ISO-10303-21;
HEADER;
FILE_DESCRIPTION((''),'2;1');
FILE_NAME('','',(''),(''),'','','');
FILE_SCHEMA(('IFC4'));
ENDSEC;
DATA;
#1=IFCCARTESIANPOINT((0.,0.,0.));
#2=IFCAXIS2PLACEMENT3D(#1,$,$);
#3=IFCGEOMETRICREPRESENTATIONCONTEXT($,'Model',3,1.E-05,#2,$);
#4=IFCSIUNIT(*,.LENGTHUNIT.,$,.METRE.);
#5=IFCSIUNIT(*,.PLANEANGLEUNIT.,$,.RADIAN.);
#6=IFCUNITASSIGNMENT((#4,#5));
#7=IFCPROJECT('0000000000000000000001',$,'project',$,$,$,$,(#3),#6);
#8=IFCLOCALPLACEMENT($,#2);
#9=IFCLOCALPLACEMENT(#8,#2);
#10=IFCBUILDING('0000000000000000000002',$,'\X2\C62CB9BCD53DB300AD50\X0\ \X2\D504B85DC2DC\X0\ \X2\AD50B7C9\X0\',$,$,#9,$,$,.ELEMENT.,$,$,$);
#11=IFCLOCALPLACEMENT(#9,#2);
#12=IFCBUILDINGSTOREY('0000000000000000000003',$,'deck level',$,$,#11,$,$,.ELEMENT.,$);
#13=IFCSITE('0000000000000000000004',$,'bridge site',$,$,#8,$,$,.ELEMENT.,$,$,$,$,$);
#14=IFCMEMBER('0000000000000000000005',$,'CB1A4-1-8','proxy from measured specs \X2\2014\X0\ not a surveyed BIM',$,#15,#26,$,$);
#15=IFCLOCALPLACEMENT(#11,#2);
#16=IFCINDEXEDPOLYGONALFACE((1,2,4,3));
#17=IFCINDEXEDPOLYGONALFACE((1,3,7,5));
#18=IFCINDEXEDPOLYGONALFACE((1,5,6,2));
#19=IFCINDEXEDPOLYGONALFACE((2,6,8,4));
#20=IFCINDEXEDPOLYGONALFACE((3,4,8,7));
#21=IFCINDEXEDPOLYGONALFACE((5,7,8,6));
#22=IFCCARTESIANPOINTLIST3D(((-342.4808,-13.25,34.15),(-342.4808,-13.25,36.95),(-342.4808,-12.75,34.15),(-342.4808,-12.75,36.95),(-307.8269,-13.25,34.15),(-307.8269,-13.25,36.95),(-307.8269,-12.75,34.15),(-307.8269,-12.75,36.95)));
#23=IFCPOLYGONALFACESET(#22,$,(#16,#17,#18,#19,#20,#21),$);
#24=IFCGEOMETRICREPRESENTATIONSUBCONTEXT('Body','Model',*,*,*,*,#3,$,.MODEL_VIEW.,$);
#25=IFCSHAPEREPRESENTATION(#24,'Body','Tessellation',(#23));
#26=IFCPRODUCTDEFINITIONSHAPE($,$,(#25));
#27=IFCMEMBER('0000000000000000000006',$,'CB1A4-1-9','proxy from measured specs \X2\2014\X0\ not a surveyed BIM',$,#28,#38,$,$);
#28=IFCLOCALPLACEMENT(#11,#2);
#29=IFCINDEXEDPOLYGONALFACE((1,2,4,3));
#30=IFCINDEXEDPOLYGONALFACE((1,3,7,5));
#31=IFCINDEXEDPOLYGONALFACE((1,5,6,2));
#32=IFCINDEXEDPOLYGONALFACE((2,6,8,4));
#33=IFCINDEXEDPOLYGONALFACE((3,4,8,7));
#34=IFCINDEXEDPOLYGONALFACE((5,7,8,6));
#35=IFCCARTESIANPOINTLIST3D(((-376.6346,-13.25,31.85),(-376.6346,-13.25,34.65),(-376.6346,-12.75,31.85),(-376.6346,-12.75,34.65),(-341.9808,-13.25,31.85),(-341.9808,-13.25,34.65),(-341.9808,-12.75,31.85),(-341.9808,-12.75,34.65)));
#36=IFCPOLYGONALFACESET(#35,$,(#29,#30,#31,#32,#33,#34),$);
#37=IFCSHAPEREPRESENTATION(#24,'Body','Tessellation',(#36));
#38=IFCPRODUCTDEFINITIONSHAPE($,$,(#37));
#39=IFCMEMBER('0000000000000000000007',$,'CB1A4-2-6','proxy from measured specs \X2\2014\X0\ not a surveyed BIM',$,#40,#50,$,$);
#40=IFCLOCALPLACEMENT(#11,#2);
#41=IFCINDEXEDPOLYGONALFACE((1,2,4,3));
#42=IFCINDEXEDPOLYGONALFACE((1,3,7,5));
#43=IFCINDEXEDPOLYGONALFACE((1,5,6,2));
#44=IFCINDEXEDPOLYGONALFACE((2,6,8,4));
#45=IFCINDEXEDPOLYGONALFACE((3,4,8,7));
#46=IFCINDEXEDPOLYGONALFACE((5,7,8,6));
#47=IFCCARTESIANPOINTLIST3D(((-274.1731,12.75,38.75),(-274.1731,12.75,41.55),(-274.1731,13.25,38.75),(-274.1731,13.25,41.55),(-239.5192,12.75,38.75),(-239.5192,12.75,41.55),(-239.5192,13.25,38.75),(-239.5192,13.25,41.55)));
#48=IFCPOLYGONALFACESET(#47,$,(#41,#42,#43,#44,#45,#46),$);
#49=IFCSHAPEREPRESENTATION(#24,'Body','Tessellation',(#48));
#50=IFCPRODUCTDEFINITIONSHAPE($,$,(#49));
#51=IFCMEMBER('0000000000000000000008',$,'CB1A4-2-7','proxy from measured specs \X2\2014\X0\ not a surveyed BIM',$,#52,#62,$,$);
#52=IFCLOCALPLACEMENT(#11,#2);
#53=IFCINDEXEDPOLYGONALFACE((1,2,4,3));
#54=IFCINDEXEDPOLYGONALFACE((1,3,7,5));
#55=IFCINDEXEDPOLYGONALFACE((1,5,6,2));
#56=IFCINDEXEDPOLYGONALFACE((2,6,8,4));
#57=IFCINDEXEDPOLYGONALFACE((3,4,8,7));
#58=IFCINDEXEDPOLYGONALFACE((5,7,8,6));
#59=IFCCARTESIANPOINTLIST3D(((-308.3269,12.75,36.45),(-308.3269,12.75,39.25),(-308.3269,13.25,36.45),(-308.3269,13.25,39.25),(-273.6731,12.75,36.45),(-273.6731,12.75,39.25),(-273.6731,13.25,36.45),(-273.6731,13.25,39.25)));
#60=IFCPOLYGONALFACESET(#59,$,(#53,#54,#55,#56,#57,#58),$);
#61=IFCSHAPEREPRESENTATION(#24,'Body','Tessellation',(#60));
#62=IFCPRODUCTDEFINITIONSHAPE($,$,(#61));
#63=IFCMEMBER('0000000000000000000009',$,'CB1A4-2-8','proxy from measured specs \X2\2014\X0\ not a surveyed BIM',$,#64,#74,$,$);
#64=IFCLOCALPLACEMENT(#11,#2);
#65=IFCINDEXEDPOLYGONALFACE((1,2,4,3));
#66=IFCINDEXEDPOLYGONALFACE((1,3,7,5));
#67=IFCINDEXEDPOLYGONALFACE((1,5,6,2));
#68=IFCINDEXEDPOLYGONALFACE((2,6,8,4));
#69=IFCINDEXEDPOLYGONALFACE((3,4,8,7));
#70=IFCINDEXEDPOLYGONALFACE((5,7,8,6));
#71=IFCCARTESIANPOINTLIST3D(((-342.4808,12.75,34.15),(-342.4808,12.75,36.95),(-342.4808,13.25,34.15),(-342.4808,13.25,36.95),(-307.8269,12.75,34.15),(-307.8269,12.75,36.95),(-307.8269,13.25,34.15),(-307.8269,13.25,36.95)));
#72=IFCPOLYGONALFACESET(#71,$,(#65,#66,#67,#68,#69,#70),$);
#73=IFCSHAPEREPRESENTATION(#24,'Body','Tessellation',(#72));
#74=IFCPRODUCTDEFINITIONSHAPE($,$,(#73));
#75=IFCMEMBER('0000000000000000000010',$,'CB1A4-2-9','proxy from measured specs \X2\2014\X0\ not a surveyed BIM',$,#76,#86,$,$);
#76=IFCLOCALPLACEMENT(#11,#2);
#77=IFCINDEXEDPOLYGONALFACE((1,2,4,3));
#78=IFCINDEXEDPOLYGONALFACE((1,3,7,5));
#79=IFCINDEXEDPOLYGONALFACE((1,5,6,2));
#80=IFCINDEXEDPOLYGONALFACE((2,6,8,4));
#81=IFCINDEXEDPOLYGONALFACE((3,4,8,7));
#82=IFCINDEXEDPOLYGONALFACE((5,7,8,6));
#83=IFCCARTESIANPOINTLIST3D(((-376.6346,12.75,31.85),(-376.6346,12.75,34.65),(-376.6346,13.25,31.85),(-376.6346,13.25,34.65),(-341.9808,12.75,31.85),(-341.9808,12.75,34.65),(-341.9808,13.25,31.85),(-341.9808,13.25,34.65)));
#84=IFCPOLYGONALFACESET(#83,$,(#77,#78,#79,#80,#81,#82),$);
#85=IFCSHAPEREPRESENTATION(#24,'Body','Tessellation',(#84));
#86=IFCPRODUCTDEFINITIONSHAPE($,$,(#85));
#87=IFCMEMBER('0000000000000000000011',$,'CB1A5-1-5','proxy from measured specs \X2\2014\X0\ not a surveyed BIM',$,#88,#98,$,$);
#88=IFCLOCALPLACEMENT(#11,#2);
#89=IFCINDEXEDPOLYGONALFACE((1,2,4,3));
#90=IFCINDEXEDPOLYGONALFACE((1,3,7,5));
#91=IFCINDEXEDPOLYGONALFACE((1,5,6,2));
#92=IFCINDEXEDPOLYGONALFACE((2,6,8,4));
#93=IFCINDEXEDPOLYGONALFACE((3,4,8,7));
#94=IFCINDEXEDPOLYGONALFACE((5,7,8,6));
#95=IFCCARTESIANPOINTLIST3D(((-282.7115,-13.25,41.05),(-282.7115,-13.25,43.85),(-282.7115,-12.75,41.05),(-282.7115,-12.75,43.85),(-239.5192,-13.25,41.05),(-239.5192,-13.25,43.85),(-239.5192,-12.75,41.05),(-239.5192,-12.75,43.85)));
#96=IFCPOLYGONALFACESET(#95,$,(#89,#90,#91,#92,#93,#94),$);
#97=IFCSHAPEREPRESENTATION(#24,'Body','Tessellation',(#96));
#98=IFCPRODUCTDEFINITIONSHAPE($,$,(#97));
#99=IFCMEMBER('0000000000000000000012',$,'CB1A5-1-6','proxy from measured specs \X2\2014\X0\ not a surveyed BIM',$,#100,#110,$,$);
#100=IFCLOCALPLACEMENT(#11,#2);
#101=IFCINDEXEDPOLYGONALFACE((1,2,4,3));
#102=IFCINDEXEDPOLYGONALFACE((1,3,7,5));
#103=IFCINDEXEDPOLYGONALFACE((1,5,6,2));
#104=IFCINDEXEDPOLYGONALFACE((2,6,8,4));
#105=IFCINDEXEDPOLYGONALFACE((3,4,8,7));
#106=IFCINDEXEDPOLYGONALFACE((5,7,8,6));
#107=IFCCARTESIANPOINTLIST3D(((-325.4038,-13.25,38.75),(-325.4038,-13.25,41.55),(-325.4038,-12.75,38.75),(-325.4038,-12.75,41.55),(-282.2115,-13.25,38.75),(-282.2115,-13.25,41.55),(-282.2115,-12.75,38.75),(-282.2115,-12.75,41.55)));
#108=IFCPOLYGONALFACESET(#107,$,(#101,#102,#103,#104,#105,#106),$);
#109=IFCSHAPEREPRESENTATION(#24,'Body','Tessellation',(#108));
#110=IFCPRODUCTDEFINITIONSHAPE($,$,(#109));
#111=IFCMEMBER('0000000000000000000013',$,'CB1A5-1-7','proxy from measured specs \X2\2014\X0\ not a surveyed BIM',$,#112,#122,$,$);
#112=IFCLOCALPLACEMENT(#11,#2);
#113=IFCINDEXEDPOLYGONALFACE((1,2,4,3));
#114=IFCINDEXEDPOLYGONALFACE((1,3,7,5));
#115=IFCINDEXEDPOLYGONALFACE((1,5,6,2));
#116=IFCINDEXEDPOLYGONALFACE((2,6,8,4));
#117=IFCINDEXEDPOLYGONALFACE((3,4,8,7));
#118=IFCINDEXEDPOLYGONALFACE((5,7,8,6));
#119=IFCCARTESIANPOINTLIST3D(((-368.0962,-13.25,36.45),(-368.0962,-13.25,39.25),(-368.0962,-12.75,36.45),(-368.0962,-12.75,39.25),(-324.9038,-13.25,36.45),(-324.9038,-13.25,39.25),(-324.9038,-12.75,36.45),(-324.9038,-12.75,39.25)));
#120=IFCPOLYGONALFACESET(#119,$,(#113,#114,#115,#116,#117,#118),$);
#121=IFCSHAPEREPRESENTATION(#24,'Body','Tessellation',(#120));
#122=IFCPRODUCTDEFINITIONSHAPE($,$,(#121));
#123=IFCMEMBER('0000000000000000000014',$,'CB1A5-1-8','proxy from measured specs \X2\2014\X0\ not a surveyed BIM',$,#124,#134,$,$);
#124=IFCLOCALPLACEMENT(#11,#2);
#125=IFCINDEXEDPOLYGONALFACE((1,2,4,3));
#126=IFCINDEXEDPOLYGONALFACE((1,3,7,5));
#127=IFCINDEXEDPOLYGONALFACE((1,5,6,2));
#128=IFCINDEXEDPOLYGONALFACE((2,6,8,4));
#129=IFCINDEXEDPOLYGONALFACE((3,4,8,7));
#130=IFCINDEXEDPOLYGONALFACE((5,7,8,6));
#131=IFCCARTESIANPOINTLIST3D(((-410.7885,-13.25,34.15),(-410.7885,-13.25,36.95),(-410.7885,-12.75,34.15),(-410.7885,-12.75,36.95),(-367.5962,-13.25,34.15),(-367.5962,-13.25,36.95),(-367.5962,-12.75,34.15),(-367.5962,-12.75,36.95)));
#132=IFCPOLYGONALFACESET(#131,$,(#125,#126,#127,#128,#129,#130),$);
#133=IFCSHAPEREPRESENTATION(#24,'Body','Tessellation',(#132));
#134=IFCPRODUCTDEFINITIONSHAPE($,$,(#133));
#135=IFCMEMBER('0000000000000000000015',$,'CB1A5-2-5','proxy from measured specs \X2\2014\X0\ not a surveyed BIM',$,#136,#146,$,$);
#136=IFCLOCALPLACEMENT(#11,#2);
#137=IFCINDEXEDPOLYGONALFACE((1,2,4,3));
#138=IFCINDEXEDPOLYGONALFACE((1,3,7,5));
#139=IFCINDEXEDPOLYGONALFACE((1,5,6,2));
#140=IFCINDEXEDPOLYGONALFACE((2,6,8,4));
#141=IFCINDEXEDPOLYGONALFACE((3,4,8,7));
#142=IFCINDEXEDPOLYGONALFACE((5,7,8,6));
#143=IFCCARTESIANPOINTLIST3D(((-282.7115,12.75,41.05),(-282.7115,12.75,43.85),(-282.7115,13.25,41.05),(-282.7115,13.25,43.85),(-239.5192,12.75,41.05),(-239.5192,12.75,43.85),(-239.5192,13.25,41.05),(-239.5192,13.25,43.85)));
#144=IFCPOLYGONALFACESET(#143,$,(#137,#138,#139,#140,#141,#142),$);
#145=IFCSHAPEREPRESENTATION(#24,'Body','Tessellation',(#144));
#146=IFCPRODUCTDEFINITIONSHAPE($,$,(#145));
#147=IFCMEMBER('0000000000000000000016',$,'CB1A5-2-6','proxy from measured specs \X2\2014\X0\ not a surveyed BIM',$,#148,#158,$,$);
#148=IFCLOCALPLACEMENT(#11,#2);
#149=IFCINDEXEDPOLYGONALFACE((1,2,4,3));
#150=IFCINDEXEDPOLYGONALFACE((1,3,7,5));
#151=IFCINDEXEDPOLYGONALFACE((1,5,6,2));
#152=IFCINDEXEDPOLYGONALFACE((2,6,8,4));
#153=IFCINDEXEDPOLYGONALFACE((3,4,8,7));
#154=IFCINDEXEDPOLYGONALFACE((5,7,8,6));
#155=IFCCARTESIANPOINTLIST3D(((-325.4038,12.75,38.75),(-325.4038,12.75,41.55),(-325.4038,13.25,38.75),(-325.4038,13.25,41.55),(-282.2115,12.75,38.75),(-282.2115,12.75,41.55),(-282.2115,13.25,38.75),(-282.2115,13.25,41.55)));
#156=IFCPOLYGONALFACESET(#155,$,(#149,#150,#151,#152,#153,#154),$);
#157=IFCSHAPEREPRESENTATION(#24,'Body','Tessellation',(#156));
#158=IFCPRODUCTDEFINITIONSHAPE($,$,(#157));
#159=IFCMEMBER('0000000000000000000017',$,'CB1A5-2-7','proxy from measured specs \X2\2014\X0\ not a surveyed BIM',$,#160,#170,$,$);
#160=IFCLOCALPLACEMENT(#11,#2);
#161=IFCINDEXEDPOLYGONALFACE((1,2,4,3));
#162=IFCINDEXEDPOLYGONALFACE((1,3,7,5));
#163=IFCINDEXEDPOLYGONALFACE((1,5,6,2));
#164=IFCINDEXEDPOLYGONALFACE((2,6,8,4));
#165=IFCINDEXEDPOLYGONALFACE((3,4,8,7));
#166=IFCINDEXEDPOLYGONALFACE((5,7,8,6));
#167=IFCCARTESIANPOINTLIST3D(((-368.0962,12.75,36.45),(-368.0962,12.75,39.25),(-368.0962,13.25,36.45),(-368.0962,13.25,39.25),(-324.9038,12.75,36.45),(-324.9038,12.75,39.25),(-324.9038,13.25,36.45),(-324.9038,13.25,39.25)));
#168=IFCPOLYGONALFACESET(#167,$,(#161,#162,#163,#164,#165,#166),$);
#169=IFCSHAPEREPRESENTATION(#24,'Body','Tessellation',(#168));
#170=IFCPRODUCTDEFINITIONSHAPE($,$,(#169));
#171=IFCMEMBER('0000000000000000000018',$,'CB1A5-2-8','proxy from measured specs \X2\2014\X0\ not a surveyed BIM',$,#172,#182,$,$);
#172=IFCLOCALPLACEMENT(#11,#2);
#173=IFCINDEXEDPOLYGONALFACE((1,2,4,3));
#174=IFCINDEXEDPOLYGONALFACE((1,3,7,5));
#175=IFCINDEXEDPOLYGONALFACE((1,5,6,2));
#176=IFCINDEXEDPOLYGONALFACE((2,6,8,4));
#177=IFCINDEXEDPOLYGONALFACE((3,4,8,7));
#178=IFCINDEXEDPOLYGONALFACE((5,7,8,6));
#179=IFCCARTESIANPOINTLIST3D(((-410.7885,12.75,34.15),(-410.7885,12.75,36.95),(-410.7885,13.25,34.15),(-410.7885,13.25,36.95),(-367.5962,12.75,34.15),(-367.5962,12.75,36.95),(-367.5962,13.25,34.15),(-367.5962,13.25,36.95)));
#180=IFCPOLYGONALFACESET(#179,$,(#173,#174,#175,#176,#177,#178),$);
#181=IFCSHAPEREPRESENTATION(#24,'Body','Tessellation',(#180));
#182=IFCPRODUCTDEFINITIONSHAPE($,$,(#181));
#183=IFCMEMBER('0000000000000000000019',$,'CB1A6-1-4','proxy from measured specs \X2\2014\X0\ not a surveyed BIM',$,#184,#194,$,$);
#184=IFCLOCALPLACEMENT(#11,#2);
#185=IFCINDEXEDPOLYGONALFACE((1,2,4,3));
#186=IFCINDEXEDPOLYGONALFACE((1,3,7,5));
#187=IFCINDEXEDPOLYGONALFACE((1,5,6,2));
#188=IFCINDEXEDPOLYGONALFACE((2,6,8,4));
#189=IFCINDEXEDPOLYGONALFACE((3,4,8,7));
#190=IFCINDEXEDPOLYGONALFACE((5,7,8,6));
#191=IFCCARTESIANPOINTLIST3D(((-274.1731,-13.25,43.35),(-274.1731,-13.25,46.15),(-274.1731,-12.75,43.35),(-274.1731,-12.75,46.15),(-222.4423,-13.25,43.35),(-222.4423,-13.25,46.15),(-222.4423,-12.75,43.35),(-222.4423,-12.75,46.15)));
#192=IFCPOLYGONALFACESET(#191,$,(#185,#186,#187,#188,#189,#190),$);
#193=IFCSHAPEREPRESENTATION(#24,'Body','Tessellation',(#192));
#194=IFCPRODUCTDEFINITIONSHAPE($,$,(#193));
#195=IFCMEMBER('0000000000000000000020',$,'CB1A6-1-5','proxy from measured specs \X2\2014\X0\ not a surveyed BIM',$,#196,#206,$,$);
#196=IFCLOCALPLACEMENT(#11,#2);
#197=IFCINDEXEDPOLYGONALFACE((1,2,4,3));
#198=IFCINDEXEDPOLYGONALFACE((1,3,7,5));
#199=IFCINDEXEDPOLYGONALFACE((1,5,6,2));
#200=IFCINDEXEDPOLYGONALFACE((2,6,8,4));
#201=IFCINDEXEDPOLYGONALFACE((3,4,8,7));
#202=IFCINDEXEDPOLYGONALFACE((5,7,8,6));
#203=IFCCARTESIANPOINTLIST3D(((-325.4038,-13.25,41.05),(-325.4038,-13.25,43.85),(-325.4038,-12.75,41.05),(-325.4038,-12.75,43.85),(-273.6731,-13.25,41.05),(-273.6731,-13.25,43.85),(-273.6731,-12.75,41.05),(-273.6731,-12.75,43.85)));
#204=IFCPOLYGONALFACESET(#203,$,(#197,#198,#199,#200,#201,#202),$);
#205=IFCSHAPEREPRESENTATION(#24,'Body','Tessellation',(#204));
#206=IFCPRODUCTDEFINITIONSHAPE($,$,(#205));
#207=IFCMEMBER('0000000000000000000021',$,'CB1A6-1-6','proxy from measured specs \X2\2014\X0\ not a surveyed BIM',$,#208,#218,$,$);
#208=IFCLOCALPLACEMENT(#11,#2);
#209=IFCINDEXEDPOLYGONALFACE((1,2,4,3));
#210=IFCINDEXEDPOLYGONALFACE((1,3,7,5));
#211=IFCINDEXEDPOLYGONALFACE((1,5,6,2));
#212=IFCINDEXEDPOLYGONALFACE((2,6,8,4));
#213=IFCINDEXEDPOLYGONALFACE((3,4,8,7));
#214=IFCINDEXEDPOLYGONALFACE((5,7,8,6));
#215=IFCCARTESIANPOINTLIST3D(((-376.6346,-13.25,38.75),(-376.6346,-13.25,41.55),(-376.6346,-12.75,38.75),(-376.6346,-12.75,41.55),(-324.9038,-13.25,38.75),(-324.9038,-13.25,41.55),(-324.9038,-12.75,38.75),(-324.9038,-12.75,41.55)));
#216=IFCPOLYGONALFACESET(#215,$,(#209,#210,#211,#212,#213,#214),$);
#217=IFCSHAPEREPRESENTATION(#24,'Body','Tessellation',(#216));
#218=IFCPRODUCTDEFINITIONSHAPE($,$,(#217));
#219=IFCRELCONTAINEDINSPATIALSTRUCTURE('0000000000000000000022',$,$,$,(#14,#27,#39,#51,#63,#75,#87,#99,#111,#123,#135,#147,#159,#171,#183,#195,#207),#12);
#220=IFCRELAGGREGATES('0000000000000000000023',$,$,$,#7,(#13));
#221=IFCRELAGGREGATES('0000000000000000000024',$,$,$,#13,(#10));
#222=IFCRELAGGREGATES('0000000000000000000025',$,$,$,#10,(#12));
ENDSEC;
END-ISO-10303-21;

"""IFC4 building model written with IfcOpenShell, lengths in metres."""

from ifc_helpers import new_model, si_unit, frame, origin, origin_2d, place, context, subcontext, project, spatial, rectangle, extrude, element, save


model = new_model("IFC4")

# Units and contexts
model_context = context("Model", 3, precision=1e-05, world=origin())
body_context = subcontext(model_context, "Body", "Model", "MODEL_VIEW")
ifc_project = project(units=[si_unit("LENGTHUNIT", "METRE"), si_unit("PLANEANGLEUNIT", "RADIAN")], contexts=[model_context])

# Site, building, storey
site_placement = place(None, origin())
site = spatial("IfcSite", under=ifc_project, at=site_placement, Name="bridge site", CompositionType="ELEMENT")
building_placement = place(site_placement, origin())
building = spatial("IfcBuilding", under=site, at=building_placement, Name="올림픽대교 프록시 교량", CompositionType="ELEMENT")
storey_placement = place(building_placement, origin())
storey = spatial("IfcBuildingStorey", under=building, at=storey_placement, Name="deck level", CompositionType="ELEMENT")

# Members
member_1_placement = place(storey_placement, frame((-325.1538, -13.0, 34.15)))
element("IfcMember", 1, at=member_1_placement, inside=storey, Name="CB1A4-1-8", Description="proxy from measured specs — not a surveyed BIM", context=body_context, shape_type="SweptSolid", body=[
    extrude(rectangle(XDim=34.6538, YDim=0.5, at=origin_2d()), origin(), (0.0, 0.0, 1.0), 2.8),
])
member_2_placement = place(storey_placement, frame((-359.3077, -13.0, 31.85)))
element("IfcMember", 2, at=member_2_placement, inside=storey, Name="CB1A4-1-9", Description="proxy from measured specs — not a surveyed BIM", context=body_context, shape_type="SweptSolid", body=[
    extrude(rectangle(XDim=34.6538, YDim=0.5, at=origin_2d()), origin(), (0.0, 0.0, 1.0), 2.8),
])
member_3_placement = place(storey_placement, frame((-256.8462, 13.0, 38.75)))
element("IfcMember", 3, at=member_3_placement, inside=storey, Name="CB1A4-2-6", Description="proxy from measured specs — not a surveyed BIM", context=body_context, shape_type="SweptSolid", body=[
    extrude(rectangle(XDim=34.6538, YDim=0.5, at=origin_2d()), origin(), (0.0, 0.0, 1.0), 2.8),
])
member_4_placement = place(storey_placement, frame((-291.0, 13.0, 36.45)))
element("IfcMember", 4, at=member_4_placement, inside=storey, Name="CB1A4-2-7", Description="proxy from measured specs — not a surveyed BIM", context=body_context, shape_type="SweptSolid", body=[
    extrude(rectangle(XDim=34.6538, YDim=0.5, at=origin_2d()), origin(), (0.0, 0.0, 1.0), 2.8),
])
member_5_placement = place(storey_placement, frame((-325.1538, 13.0, 34.15)))
element("IfcMember", 5, at=member_5_placement, inside=storey, Name="CB1A4-2-8", Description="proxy from measured specs — not a surveyed BIM", context=body_context, shape_type="SweptSolid", body=[
    extrude(rectangle(XDim=34.6538, YDim=0.5, at=origin_2d()), origin(), (0.0, 0.0, 1.0), 2.8),
])
member_6_placement = place(storey_placement, frame((-359.3077, 13.0, 31.85)))
element("IfcMember", 6, at=member_6_placement, inside=storey, Name="CB1A4-2-9", Description="proxy from measured specs — not a surveyed BIM", context=body_context, shape_type="SweptSolid", body=[
    extrude(rectangle(XDim=34.6538, YDim=0.5, at=origin_2d()), origin(), (0.0, 0.0, 1.0), 2.8),
])
member_7_placement = place(storey_placement, frame((-261.1154, -13.0, 41.05)))
element("IfcMember", 7, at=member_7_placement, inside=storey, Name="CB1A5-1-5", Description="proxy from measured specs — not a surveyed BIM", context=body_context, shape_type="SweptSolid", body=[
    extrude(rectangle(XDim=43.1923, YDim=0.5, at=origin_2d()), origin(), (0.0, 0.0, 1.0), 2.8),
])
for number, where, name in (
    (8, (-303.8077, -13.0, 38.75), "CB1A5-1-6"),
    (9, (-346.5, -13.0, 36.45), "CB1A5-1-7"),
):
    element("IfcMember", number, at=place(storey_placement, frame(where)), inside=storey, Name=name, Description="proxy from measured specs — not a surveyed BIM", context=body_context, shape_type="SweptSolid", body=[
        extrude(rectangle(XDim=43.1923, YDim=0.5, at=origin_2d()), origin(), (0.0, 0.0, 1.0), 2.8),
    ])
member_8_placement = place(storey_placement, frame((-389.1923, -13.0, 34.15)))
element("IfcMember", 10, at=member_8_placement, inside=storey, Name="CB1A5-1-8", Description="proxy from measured specs — not a surveyed BIM", context=body_context, shape_type="SweptSolid", body=[
    extrude(rectangle(XDim=43.1923, YDim=0.5, at=origin_2d()), origin(), (0.0, 0.0, 1.0), 2.8),
])
member_9_placement = place(storey_placement, frame((-261.1154, 13.0, 41.05)))
element("IfcMember", 11, at=member_9_placement, inside=storey, Name="CB1A5-2-5", Description="proxy from measured specs — not a surveyed BIM", context=body_context, shape_type="SweptSolid", body=[
    extrude(rectangle(XDim=43.1923, YDim=0.5, at=origin_2d()), origin(), (0.0, 0.0, 1.0), 2.8),
])
for number, where, name in (
    (12, (-303.8077, 13.0, 38.75), "CB1A5-2-6"),
    (13, (-346.5, 13.0, 36.45), "CB1A5-2-7"),
):
    element("IfcMember", number, at=place(storey_placement, frame(where)), inside=storey, Name=name, Description="proxy from measured specs — not a surveyed BIM", context=body_context, shape_type="SweptSolid", body=[
        extrude(rectangle(XDim=43.1923, YDim=0.5, at=origin_2d()), origin(), (0.0, 0.0, 1.0), 2.8),
    ])
member_10_placement = place(storey_placement, frame((-389.1923, 13.0, 34.15)))
element("IfcMember", 14, at=member_10_placement, inside=storey, Name="CB1A5-2-8", Description="proxy from measured specs — not a surveyed BIM", context=body_context, shape_type="SweptSolid", body=[
    extrude(rectangle(XDim=43.1923, YDim=0.5, at=origin_2d()), origin(), (0.0, 0.0, 1.0), 2.8),
])
member_11_placement = place(storey_placement, frame((-248.3077, -13.0, 43.35)))
element("IfcMember", 15, at=member_11_placement, inside=storey, Name="CB1A6-1-4", Description="proxy from measured specs — not a surveyed BIM", context=body_context, shape_type="SweptSolid", body=[
    extrude(rectangle(XDim=51.7308, YDim=0.5, at=origin_2d()), origin(), (0.0, 0.0, 1.0), 2.8),
])
for number, where, name in (
    (16, (-299.5385, -13.0, 41.05), "CB1A6-1-5"),
    (17, (-350.7692, -13.0, 38.75), "CB1A6-1-6"),
):
    element("IfcMember", number, at=place(storey_placement, frame(where)), inside=storey, Name=name, Description="proxy from measured specs — not a surveyed BIM", context=body_context, shape_type="SweptSolid", body=[
        extrude(rectangle(XDim=51.7308, YDim=0.5, at=origin_2d()), origin(), (0.0, 0.0, 1.0), 2.8),
    ])

save(model, "model.ifc")
